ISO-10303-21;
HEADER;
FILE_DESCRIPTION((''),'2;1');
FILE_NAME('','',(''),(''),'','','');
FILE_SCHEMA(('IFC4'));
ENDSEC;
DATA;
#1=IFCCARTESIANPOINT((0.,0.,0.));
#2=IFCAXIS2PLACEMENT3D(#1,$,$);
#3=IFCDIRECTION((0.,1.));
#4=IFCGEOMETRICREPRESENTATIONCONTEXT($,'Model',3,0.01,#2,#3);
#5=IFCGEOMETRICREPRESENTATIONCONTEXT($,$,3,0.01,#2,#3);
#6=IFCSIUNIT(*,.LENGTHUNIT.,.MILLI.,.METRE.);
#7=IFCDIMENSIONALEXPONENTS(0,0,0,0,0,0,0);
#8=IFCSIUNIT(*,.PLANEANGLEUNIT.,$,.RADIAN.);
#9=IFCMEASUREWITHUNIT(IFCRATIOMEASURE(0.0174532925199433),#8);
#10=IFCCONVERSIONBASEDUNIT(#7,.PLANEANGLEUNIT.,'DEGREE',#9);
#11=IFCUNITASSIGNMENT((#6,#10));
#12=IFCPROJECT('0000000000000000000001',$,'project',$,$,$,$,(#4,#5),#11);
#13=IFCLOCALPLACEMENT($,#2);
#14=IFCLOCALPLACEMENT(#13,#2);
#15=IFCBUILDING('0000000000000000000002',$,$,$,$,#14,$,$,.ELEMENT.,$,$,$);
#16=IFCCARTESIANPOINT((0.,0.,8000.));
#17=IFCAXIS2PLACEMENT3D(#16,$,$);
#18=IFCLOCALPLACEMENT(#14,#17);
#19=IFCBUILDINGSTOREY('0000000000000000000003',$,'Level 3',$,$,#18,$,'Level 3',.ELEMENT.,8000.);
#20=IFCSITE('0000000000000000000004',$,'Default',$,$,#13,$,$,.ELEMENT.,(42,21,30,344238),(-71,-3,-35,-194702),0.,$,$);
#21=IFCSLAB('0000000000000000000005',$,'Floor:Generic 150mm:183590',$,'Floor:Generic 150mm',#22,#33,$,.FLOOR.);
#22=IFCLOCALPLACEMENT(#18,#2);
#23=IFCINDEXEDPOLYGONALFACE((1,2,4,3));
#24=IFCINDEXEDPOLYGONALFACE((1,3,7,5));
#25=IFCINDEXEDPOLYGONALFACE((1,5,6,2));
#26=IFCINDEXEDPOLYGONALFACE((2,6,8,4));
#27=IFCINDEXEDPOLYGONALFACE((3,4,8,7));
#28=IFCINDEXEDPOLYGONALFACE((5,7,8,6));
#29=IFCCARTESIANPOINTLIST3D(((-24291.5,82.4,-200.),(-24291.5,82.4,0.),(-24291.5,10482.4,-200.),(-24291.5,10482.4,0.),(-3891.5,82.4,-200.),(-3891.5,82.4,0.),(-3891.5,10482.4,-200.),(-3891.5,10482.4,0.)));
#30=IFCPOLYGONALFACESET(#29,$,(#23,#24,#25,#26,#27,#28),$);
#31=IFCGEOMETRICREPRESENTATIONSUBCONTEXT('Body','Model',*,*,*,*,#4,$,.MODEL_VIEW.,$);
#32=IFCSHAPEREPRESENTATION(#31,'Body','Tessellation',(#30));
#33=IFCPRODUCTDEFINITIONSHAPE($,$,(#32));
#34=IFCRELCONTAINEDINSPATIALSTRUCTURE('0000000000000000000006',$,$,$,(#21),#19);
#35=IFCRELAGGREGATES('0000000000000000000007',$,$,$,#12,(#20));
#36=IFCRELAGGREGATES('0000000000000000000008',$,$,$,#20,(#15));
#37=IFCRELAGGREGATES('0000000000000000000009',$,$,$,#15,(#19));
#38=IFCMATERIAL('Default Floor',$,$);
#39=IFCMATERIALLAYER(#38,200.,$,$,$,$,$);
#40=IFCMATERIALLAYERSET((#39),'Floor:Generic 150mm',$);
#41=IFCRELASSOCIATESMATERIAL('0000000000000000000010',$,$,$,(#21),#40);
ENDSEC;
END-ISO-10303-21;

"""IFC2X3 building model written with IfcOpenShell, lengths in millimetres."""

from ifc_helpers import new_model, entity, si_unit, converted_unit, direction, frame, origin, origin_2d_with_axis, place, context, subcontext, project, spatial, rectangle, extrude, material, layer, layer_set, layer_usage, element, save


model = new_model("IFC2X3")

# Units and contexts
model_context = context("Model", 3, precision=0.01, world=origin(), true_north=direction((0.0, 1.0)))
context_of_model = context(None, 3, precision=0.01, world=origin(), true_north=direction((0.0, 1.0)))
body_context = subcontext(model_context, "Body", "Model", "MODEL_VIEW")
ifc_project = project(units=[si_unit("LENGTHUNIT", "METRE", prefix="MILLI"), converted_unit("PLANEANGLEUNIT", "DEGREE", entity("IfcRatioMeasure", 0.0174532925199433), si_unit("PLANEANGLEUNIT", "RADIAN"), dimensions=[0, 0, 0, 0, 0, 0, 0])], contexts=[model_context, context_of_model])

# Site, building, storey
site_placement = place(None, origin())
site = spatial("IfcSite", under=ifc_project, at=site_placement, Name="Default", CompositionType="ELEMENT", RefLatitude=(42, 21, 30, 344238), RefLongitude=(-71, -3, -35, -194702), RefElevation=0.0)
building_placement = place(site_placement, origin())
building = spatial("IfcBuilding", under=site, at=building_placement, CompositionType="ELEMENT")
storey_placement = place(building_placement, frame((0.0, 0.0, 8000.0)))
storey = spatial("IfcBuildingStorey", under=building, at=storey_placement, Name="Level 3", LongName="Level 3", CompositionType="ELEMENT", Elevation=8000.0)

# Slab
ifc_material = material(Name="Default Floor")
ifc_layer = layer(ifc_material, 200.0)
ifc_layer_set = layer_set([ifc_layer], Name="Floor:Generic 150mm")
ifc_layer_usage = layer_usage(ifc_layer_set, "AXIS3", "POSITIVE", 0.0)
slab_placement = place(storey_placement, origin())
element("IfcSlab", 1, at=slab_placement, inside=storey, material=ifc_layer_usage, Name="Floor:Generic 150mm:183590", ObjectType="Floor:Generic 150mm", PredefinedType="FLOOR", context=body_context, shape_type="SweptSolid", body=[
    extrude(rectangle(XDim=10400.0, YDim=20400.0, at=origin_2d_with_axis()), frame((-14091.5, 5282.4, 0.0), z_axis=(0.0, 0.0, -1.0), x_axis=(0.0, 1.0, 0.0)), (0.0, 0.0, 1.0), 200.0),
])

save(model, "model.ifc")
